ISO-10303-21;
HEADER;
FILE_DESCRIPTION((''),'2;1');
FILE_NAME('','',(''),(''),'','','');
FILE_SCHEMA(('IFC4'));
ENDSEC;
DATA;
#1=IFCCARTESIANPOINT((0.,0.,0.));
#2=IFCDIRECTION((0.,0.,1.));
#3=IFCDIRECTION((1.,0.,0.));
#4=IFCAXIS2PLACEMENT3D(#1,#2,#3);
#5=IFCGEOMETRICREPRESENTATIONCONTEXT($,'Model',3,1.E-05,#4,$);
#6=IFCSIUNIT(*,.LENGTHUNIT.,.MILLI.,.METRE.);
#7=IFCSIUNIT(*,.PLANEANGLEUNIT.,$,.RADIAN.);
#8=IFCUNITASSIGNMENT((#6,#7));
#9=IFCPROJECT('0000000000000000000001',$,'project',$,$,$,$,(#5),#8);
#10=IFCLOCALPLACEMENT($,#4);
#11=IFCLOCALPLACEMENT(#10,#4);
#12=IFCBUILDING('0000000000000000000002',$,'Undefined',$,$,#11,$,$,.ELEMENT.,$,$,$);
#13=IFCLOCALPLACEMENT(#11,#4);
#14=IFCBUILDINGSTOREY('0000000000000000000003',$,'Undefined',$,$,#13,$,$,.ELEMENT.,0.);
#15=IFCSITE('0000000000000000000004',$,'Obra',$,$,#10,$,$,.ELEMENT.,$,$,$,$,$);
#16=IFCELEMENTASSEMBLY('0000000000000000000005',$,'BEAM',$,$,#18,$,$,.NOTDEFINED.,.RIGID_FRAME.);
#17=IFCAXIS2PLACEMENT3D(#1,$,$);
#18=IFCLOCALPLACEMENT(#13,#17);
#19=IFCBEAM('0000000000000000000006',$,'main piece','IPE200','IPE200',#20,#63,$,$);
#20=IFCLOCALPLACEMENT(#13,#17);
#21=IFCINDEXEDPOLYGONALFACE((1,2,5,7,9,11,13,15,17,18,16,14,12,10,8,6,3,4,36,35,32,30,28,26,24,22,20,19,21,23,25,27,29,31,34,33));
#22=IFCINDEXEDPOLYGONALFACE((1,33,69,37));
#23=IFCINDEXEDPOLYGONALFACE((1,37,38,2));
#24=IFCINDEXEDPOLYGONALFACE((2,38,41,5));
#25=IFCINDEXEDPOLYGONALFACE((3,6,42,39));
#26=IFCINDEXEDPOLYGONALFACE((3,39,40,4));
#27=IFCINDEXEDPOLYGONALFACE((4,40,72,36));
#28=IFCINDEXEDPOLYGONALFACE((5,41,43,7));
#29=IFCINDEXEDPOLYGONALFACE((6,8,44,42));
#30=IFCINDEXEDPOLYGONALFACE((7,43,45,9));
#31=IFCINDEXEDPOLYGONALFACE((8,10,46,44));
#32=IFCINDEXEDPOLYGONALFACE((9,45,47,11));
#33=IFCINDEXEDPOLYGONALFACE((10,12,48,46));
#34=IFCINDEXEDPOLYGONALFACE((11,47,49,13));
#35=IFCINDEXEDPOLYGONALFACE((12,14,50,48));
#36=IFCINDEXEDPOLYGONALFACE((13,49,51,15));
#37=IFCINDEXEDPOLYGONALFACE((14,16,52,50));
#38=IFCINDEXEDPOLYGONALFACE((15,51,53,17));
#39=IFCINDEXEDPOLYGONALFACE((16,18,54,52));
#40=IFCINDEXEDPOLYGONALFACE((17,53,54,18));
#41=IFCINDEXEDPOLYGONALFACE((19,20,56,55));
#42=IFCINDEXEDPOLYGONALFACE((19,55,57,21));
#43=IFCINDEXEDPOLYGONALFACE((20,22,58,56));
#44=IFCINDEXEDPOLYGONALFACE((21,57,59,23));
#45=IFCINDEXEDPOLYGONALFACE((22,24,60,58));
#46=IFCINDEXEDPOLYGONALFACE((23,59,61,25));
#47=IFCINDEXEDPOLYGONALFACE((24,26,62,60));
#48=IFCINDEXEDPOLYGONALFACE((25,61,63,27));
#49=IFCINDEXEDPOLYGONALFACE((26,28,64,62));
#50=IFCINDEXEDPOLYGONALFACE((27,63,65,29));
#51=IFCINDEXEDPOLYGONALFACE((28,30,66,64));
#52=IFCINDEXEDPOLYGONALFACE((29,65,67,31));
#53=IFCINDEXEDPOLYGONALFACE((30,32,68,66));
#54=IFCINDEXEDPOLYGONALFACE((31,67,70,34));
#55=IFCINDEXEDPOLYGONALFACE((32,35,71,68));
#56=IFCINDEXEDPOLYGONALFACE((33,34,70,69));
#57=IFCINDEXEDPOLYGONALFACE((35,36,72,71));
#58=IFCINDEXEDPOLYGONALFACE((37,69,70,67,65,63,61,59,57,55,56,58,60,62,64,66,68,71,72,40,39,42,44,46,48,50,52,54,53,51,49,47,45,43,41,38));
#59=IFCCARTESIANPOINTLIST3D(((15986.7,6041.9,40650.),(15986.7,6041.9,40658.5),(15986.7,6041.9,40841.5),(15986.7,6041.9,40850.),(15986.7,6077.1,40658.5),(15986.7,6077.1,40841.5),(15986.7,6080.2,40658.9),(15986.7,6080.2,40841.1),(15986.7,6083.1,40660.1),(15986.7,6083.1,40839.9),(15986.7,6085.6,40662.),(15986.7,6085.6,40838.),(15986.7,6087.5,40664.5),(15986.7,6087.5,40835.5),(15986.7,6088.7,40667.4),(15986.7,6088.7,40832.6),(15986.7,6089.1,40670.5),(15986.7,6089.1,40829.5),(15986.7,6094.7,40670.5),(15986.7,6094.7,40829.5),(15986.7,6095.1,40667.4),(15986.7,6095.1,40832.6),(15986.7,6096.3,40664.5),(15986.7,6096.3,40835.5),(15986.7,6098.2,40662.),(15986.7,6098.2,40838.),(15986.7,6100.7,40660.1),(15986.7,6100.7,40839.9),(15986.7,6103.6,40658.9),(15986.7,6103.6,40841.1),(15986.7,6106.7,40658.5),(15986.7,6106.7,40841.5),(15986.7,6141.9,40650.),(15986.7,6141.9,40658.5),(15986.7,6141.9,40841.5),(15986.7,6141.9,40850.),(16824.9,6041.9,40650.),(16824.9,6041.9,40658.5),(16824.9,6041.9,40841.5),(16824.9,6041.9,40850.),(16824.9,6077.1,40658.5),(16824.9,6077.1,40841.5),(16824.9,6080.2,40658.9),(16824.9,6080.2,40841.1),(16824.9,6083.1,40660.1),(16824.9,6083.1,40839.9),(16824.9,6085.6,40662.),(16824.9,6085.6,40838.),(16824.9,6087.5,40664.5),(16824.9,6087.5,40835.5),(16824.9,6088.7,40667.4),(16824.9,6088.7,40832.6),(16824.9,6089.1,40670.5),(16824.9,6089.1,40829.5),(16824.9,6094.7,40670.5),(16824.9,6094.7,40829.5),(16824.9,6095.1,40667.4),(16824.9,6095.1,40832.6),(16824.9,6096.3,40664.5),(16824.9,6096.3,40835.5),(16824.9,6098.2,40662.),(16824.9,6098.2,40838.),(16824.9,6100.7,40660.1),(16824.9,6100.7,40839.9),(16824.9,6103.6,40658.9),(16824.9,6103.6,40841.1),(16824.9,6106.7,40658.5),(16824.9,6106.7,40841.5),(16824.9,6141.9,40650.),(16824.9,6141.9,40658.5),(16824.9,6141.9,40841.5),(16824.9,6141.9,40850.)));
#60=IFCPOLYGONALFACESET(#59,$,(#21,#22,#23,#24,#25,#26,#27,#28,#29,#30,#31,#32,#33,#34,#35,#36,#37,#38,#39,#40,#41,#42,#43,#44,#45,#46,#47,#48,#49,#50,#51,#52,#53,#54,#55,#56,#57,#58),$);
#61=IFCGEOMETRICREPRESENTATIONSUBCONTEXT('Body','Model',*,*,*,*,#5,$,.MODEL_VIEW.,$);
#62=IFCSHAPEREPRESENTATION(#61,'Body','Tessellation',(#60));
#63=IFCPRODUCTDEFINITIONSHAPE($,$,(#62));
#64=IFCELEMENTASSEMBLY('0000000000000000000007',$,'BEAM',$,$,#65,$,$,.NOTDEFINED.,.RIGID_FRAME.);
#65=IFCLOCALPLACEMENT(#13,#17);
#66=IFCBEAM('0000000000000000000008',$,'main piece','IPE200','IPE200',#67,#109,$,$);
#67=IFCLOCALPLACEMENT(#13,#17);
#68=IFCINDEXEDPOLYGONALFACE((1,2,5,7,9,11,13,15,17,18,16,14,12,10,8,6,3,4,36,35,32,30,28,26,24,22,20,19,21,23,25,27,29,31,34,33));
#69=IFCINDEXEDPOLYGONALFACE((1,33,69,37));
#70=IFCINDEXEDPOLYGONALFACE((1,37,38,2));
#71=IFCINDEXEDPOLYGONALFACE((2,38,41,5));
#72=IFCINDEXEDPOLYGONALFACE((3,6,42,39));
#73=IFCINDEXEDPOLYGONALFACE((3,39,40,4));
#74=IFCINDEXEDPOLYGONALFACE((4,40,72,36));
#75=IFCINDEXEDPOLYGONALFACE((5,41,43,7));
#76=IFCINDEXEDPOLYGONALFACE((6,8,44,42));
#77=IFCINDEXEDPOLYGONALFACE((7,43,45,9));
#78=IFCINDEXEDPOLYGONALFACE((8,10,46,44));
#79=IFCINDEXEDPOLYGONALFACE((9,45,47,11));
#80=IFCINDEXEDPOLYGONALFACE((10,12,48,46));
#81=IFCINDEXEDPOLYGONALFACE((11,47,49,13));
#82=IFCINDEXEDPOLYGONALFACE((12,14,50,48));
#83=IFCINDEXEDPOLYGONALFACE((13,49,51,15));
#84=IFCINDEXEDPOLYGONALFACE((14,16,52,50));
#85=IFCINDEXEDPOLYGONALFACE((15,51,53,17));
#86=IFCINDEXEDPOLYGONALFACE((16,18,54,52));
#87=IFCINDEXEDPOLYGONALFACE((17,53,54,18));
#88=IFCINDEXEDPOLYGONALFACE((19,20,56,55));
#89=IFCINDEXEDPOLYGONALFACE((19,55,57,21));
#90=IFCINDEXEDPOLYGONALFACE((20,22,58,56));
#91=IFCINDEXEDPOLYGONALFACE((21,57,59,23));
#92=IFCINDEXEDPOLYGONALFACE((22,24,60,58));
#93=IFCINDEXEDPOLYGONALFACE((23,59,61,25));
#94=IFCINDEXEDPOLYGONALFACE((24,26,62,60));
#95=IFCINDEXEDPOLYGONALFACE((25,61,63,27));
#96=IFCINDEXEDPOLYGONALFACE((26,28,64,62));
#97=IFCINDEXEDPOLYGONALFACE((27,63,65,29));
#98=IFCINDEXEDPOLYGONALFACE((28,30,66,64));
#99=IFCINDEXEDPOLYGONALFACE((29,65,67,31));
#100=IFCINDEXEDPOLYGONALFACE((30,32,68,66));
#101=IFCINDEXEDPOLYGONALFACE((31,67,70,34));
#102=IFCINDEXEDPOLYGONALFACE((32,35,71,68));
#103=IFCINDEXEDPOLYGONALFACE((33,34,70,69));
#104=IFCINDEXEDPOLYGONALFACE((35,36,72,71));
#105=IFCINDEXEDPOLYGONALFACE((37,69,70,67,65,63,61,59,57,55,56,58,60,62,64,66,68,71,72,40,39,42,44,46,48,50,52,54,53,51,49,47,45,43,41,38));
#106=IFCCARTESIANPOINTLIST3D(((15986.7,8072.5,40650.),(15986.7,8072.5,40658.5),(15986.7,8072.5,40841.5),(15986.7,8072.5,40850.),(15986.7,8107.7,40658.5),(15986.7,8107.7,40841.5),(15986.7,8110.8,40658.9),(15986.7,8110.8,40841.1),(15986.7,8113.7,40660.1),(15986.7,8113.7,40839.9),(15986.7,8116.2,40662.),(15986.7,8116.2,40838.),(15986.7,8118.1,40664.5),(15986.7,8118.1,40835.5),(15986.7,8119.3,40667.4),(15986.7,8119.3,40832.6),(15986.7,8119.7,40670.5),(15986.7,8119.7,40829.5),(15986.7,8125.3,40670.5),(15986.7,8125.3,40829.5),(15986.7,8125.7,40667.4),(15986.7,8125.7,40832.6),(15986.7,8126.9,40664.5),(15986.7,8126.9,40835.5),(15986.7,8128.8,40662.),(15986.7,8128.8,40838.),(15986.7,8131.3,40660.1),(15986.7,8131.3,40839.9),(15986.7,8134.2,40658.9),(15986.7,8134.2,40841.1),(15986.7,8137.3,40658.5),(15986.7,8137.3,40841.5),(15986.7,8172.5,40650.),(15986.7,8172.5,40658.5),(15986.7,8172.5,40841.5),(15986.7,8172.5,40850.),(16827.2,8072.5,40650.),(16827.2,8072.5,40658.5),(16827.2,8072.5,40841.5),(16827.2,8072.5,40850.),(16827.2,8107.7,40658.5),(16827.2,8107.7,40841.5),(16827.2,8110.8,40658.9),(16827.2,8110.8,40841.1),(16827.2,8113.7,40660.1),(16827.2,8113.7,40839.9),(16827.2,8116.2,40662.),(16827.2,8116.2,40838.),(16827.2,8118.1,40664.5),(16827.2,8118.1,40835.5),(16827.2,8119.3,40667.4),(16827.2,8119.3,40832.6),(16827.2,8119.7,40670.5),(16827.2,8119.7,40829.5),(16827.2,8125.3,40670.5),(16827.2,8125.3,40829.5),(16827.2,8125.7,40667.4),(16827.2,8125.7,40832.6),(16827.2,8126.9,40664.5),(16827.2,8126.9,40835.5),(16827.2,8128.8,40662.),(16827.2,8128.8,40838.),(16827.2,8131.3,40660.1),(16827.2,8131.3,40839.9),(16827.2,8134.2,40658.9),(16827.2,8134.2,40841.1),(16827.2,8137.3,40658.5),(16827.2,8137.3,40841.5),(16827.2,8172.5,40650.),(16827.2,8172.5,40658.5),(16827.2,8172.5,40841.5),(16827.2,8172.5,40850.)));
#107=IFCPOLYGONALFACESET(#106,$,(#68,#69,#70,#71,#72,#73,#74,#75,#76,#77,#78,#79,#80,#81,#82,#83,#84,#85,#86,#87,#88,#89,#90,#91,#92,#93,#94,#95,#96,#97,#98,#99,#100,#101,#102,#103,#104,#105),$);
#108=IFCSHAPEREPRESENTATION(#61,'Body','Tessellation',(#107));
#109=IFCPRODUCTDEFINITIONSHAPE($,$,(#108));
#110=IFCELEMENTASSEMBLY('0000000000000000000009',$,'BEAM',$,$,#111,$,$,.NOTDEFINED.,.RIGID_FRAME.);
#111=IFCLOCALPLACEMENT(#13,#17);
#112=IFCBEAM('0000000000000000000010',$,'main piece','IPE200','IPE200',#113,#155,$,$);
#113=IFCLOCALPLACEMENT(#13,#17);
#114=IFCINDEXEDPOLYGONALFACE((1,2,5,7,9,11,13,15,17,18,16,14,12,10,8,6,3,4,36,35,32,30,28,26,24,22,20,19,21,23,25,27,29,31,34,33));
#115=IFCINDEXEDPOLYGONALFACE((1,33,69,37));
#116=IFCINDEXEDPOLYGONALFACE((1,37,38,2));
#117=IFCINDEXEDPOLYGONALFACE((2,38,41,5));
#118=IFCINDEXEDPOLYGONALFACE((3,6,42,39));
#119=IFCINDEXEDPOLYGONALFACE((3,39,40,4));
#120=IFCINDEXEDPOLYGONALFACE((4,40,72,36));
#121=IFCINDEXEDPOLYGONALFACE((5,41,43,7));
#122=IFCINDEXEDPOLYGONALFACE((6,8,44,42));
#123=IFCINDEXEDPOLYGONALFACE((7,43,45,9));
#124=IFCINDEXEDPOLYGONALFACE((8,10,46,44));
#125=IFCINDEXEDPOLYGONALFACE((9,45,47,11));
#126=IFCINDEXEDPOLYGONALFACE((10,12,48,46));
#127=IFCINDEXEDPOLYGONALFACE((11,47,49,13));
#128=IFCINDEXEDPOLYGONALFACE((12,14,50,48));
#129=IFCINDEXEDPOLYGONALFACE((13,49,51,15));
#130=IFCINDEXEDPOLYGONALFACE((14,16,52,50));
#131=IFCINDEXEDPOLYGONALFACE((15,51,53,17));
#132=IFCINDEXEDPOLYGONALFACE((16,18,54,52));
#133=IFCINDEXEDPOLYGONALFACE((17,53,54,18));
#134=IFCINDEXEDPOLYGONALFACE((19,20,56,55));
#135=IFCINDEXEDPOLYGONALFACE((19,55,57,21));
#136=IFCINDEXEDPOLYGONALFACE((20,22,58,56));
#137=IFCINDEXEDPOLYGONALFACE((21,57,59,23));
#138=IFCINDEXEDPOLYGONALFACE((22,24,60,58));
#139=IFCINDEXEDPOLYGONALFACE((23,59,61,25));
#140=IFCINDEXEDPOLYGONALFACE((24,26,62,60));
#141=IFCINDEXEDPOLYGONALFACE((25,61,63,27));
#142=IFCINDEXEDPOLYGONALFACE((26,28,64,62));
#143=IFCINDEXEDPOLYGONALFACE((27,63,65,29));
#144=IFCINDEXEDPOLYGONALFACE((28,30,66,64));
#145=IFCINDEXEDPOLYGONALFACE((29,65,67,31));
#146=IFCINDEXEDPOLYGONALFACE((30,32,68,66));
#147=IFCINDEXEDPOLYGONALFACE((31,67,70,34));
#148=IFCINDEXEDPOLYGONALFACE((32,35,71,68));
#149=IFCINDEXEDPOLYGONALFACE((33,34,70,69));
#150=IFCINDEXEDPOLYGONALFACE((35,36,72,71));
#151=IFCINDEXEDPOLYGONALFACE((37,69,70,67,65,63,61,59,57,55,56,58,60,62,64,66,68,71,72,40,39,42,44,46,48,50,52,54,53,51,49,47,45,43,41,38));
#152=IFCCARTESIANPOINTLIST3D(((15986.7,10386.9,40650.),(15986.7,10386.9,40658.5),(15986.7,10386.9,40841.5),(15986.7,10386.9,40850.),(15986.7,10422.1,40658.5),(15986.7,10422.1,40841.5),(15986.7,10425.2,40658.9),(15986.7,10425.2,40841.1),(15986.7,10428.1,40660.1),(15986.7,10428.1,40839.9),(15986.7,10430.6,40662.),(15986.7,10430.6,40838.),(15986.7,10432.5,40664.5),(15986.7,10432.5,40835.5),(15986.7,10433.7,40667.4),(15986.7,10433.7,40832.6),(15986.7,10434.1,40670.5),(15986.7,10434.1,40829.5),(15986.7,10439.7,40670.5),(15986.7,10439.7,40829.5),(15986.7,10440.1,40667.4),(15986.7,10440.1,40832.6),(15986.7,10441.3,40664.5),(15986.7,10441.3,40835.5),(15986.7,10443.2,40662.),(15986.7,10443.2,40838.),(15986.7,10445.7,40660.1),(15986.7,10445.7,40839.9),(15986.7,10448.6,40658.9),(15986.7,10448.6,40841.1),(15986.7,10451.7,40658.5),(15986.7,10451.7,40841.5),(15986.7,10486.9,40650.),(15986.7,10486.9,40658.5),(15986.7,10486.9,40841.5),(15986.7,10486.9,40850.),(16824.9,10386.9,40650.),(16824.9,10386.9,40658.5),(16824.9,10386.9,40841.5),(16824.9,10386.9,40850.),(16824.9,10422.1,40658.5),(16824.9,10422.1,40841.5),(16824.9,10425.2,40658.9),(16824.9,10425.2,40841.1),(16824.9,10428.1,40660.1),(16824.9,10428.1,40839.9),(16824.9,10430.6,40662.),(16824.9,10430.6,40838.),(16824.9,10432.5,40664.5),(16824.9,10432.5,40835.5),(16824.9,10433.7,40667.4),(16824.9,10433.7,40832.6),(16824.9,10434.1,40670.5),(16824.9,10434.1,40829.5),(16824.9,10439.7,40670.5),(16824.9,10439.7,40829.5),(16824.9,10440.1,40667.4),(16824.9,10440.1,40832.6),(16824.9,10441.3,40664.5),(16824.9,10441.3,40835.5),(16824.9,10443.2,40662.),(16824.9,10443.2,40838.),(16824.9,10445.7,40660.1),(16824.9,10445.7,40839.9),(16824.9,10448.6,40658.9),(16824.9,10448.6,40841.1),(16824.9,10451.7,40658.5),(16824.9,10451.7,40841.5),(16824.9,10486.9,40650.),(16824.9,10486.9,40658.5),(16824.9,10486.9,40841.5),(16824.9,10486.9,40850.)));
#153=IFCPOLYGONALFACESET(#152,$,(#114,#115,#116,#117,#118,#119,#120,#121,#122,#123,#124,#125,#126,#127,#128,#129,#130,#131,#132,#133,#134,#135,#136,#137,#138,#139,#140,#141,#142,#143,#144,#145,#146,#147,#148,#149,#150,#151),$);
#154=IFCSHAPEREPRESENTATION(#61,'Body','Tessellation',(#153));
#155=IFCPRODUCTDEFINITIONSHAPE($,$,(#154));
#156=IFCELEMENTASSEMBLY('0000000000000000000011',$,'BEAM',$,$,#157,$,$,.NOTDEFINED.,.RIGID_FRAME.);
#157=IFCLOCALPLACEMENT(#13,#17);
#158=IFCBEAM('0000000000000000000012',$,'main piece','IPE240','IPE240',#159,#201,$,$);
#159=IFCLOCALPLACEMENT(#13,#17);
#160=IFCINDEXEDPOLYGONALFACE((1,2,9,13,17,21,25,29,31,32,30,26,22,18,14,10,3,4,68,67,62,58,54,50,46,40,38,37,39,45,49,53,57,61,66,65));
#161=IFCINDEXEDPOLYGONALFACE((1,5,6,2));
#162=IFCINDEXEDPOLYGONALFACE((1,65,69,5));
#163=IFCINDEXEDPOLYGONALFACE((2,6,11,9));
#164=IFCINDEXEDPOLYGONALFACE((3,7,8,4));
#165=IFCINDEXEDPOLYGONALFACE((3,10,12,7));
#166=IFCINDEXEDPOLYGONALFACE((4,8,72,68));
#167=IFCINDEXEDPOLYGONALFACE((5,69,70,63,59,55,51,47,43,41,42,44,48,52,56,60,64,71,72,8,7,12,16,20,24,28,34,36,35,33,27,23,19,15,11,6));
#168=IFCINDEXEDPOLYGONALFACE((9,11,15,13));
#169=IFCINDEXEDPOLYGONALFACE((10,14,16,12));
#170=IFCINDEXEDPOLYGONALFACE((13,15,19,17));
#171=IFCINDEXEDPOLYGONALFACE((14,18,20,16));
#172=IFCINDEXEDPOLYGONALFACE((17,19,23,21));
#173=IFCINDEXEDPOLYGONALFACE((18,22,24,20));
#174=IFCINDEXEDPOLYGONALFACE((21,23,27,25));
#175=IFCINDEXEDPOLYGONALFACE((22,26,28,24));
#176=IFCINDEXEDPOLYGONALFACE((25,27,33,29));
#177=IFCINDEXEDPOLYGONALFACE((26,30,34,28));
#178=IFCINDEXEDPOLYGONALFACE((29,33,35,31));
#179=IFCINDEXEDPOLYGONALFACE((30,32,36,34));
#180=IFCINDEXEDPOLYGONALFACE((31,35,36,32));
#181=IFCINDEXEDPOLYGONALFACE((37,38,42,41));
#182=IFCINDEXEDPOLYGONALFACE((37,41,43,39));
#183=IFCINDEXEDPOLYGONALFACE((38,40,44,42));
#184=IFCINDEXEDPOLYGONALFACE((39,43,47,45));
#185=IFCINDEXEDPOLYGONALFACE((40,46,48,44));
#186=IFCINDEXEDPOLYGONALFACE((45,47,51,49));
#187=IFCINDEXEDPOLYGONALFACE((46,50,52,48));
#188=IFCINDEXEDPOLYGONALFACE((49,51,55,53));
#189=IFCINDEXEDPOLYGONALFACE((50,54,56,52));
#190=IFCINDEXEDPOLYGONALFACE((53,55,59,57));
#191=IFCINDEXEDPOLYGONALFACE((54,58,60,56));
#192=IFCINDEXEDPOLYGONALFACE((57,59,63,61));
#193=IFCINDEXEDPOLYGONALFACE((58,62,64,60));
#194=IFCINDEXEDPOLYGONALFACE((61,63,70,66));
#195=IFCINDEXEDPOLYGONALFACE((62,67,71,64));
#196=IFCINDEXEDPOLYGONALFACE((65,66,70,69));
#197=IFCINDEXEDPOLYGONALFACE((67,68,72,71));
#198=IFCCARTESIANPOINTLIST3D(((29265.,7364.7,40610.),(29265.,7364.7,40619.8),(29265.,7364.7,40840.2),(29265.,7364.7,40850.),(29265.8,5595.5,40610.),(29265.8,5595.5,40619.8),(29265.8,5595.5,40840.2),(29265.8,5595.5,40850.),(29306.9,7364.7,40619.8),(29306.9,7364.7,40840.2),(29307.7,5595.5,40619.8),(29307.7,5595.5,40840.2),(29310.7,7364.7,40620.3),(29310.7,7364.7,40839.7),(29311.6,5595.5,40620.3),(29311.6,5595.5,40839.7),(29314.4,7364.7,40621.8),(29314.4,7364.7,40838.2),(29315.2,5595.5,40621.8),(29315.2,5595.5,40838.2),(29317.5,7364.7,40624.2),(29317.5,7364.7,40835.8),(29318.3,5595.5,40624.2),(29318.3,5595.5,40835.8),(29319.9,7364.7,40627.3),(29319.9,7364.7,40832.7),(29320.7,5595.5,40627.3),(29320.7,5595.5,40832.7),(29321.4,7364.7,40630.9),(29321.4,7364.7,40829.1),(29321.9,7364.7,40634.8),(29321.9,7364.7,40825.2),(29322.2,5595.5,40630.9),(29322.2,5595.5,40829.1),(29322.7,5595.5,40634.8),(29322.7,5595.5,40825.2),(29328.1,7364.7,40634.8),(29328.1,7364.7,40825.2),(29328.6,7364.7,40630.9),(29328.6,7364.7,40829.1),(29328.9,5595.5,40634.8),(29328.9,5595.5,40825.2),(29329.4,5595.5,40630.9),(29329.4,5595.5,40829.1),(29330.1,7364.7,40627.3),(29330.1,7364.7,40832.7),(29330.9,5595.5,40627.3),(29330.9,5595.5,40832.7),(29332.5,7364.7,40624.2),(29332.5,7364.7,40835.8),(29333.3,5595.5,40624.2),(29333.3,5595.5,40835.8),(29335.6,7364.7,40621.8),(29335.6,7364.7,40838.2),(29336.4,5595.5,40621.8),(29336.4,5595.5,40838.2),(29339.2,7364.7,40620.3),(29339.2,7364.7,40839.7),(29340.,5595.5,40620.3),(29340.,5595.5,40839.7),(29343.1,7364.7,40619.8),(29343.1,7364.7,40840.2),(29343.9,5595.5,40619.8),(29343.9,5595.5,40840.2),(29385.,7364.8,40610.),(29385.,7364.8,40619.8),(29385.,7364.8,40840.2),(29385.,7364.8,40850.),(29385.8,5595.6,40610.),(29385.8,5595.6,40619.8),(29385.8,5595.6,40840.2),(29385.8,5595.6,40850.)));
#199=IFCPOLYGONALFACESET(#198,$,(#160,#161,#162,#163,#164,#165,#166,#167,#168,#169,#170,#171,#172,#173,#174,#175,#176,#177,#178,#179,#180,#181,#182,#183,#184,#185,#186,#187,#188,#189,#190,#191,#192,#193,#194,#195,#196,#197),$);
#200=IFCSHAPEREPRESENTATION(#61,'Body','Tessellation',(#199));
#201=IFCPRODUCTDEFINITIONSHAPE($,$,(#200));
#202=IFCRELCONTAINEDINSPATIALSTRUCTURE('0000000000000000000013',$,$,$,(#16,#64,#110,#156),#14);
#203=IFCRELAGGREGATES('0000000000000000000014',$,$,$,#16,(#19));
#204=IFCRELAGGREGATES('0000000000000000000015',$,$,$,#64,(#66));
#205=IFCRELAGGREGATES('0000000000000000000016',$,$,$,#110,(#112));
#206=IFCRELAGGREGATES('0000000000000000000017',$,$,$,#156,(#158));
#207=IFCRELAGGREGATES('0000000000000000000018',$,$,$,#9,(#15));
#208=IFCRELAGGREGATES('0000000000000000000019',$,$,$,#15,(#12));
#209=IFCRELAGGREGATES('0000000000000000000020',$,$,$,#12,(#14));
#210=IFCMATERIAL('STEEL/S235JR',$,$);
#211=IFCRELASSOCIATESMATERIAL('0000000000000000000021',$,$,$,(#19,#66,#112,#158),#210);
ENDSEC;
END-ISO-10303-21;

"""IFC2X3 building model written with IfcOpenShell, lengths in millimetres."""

from ifc_helpers import new_model, si_unit, frame, origin_with_axes, origin_2d_with_axis, place, context, subcontext, project, spatial, i_section, extrude, material, element, aggregate, save


model = new_model("IFC2X3")

# Units and contexts
model_context = context("Model", 3, precision=1e-05, world=origin_with_axes())
body_context = subcontext(model_context, "Body", "Model", "MODEL_VIEW")
ifc_project = project(units=[si_unit("LENGTHUNIT", "METRE", prefix="MILLI"), si_unit("PLANEANGLEUNIT", "RADIAN")], contexts=[model_context])

# Site, building, storey
site_placement = place(None, origin_with_axes())
site = spatial("IfcSite", under=ifc_project, at=site_placement, Name="Obra", CompositionType="ELEMENT")
building_placement = place(site_placement, origin_with_axes())
building = spatial("IfcBuilding", under=site, at=building_placement, Name="Undefined", CompositionType="ELEMENT")
storey_placement = place(building_placement, origin_with_axes())
storey = spatial("IfcBuildingStorey", under=building, at=storey_placement, Name="Undefined", CompositionType="ELEMENT", Elevation=0.0)

# Element assemblies, beams
ifc_material_1 = material(Name="STEEL/S235JR")
assembly_1_placement = place(storey_placement, origin_with_axes())
assembly_1 = element("IfcElementAssembly", 1, at=assembly_1_placement, inside=storey, Name="BEAM", AssemblyPlace="NOTDEFINED", PredefinedType="RIGID_FRAME")
beam_1_placement = place(assembly_1_placement, frame((16825.0, 6091.9, 40750.0), z_axis=(0.0, 0.0, 1.0), x_axis=(-1.0, 0.0, 0.0)))
beam_1 = element("IfcBeam", 2, at=beam_1_placement, material=ifc_material_1, Name="main piece", Description="IPE200", ObjectType="IPE200", context=body_context, shape_type="SweptSolid", body=[
    extrude(i_section(OverallWidth=100.0, OverallDepth=200.0, WebThickness=5.6, FlangeThickness=8.5, FilletRadius=12.0, at=origin_2d_with_axis()), frame((838.3, 0.0, 0.0), z_axis=(-1.0, 0.0, 0.0), x_axis=(0.0, -1.0, 0.0)), (0.0, 0.0, 1.0), 838.2),
])
aggregate(assembly_1, [beam_1])
assembly_2_placement = place(storey_placement, origin_with_axes())
assembly_2 = element("IfcElementAssembly", 3, at=assembly_2_placement, inside=storey, Name="BEAM", AssemblyPlace="NOTDEFINED", PredefinedType="RIGID_FRAME")
beam_2_placement = place(assembly_2_placement, frame((15986.7, 8122.5, 40750.0), z_axis=(0.0, 0.0, 1.0), x_axis=(1.0, 0.0, 0.0)))
beam_2 = element("IfcBeam", 4, at=beam_2_placement, material=ifc_material_1, Name="main piece", Description="IPE200", ObjectType="IPE200", context=body_context, shape_type="SweptSolid", body=[
    extrude(i_section(OverallWidth=100.0, OverallDepth=200.0, WebThickness=5.6, FlangeThickness=8.5, FilletRadius=12.0, at=origin_2d_with_axis()), frame((840.5, 0.0, 0.0), z_axis=(-1.0, 0.0, 0.0), x_axis=(0.0, -1.0, 0.0)), (0.0, 0.0, 1.0), 840.5),
])
aggregate(assembly_2, [beam_2])
assembly_3_placement = place(storey_placement, origin_with_axes())
assembly_3 = element("IfcElementAssembly", 5, at=assembly_3_placement, inside=storey, Name="BEAM", AssemblyPlace="NOTDEFINED", PredefinedType="RIGID_FRAME")
beam_3_placement = place(assembly_3_placement, frame((16825.0, 10436.9, 40750.0), z_axis=(0.0, 0.0, 1.0), x_axis=(-1.0, 0.0, 0.0)))
beam_3 = element("IfcBeam", 6, at=beam_3_placement, material=ifc_material_1, Name="main piece", Description="IPE200", ObjectType="IPE200", context=body_context, shape_type="SweptSolid", body=[
    extrude(i_section(OverallWidth=100.0, OverallDepth=200.0, WebThickness=5.6, FlangeThickness=8.5, FilletRadius=12.0, at=origin_2d_with_axis()), frame((838.3, 0.0, 0.0), z_axis=(-1.0, 0.0, 0.0), x_axis=(0.0, -1.0, 0.0)), (0.0, 0.0, 1.0), 838.2),
])
aggregate(assembly_3, [beam_3])
assembly_4_placement = place(storey_placement, origin_with_axes())
assembly_4 = element("IfcElementAssembly", 7, at=assembly_4_placement, inside=storey, Name="BEAM", AssemblyPlace="NOTDEFINED", PredefinedType="RIGID_FRAME")
beam_4_placement = place(assembly_4_placement, frame((29325.0, 7364.7, 40730.0), z_axis=(0.0, 0.0, 1.0), x_axis=(0.000488, -1.0, 0.0)))
beam_4 = element("IfcBeam", 8, at=beam_4_placement, material=ifc_material_1, Name="main piece", Description="IPE240", ObjectType="IPE240", context=body_context, shape_type="SweptSolid", body=[
    extrude(i_section(OverallWidth=120.0, OverallDepth=240.0, WebThickness=6.2, FlangeThickness=9.8, FilletRadius=15.0, at=origin_2d_with_axis()), frame((1769.2, 0.0, 0.0), z_axis=(-1.0, 0.0, 0.0), x_axis=(0.0, -1.0, 0.0)), (0.0, 0.0, 1.0), 1769.2),
])
aggregate(assembly_4, [beam_4])

save(model, "model.ifc")
